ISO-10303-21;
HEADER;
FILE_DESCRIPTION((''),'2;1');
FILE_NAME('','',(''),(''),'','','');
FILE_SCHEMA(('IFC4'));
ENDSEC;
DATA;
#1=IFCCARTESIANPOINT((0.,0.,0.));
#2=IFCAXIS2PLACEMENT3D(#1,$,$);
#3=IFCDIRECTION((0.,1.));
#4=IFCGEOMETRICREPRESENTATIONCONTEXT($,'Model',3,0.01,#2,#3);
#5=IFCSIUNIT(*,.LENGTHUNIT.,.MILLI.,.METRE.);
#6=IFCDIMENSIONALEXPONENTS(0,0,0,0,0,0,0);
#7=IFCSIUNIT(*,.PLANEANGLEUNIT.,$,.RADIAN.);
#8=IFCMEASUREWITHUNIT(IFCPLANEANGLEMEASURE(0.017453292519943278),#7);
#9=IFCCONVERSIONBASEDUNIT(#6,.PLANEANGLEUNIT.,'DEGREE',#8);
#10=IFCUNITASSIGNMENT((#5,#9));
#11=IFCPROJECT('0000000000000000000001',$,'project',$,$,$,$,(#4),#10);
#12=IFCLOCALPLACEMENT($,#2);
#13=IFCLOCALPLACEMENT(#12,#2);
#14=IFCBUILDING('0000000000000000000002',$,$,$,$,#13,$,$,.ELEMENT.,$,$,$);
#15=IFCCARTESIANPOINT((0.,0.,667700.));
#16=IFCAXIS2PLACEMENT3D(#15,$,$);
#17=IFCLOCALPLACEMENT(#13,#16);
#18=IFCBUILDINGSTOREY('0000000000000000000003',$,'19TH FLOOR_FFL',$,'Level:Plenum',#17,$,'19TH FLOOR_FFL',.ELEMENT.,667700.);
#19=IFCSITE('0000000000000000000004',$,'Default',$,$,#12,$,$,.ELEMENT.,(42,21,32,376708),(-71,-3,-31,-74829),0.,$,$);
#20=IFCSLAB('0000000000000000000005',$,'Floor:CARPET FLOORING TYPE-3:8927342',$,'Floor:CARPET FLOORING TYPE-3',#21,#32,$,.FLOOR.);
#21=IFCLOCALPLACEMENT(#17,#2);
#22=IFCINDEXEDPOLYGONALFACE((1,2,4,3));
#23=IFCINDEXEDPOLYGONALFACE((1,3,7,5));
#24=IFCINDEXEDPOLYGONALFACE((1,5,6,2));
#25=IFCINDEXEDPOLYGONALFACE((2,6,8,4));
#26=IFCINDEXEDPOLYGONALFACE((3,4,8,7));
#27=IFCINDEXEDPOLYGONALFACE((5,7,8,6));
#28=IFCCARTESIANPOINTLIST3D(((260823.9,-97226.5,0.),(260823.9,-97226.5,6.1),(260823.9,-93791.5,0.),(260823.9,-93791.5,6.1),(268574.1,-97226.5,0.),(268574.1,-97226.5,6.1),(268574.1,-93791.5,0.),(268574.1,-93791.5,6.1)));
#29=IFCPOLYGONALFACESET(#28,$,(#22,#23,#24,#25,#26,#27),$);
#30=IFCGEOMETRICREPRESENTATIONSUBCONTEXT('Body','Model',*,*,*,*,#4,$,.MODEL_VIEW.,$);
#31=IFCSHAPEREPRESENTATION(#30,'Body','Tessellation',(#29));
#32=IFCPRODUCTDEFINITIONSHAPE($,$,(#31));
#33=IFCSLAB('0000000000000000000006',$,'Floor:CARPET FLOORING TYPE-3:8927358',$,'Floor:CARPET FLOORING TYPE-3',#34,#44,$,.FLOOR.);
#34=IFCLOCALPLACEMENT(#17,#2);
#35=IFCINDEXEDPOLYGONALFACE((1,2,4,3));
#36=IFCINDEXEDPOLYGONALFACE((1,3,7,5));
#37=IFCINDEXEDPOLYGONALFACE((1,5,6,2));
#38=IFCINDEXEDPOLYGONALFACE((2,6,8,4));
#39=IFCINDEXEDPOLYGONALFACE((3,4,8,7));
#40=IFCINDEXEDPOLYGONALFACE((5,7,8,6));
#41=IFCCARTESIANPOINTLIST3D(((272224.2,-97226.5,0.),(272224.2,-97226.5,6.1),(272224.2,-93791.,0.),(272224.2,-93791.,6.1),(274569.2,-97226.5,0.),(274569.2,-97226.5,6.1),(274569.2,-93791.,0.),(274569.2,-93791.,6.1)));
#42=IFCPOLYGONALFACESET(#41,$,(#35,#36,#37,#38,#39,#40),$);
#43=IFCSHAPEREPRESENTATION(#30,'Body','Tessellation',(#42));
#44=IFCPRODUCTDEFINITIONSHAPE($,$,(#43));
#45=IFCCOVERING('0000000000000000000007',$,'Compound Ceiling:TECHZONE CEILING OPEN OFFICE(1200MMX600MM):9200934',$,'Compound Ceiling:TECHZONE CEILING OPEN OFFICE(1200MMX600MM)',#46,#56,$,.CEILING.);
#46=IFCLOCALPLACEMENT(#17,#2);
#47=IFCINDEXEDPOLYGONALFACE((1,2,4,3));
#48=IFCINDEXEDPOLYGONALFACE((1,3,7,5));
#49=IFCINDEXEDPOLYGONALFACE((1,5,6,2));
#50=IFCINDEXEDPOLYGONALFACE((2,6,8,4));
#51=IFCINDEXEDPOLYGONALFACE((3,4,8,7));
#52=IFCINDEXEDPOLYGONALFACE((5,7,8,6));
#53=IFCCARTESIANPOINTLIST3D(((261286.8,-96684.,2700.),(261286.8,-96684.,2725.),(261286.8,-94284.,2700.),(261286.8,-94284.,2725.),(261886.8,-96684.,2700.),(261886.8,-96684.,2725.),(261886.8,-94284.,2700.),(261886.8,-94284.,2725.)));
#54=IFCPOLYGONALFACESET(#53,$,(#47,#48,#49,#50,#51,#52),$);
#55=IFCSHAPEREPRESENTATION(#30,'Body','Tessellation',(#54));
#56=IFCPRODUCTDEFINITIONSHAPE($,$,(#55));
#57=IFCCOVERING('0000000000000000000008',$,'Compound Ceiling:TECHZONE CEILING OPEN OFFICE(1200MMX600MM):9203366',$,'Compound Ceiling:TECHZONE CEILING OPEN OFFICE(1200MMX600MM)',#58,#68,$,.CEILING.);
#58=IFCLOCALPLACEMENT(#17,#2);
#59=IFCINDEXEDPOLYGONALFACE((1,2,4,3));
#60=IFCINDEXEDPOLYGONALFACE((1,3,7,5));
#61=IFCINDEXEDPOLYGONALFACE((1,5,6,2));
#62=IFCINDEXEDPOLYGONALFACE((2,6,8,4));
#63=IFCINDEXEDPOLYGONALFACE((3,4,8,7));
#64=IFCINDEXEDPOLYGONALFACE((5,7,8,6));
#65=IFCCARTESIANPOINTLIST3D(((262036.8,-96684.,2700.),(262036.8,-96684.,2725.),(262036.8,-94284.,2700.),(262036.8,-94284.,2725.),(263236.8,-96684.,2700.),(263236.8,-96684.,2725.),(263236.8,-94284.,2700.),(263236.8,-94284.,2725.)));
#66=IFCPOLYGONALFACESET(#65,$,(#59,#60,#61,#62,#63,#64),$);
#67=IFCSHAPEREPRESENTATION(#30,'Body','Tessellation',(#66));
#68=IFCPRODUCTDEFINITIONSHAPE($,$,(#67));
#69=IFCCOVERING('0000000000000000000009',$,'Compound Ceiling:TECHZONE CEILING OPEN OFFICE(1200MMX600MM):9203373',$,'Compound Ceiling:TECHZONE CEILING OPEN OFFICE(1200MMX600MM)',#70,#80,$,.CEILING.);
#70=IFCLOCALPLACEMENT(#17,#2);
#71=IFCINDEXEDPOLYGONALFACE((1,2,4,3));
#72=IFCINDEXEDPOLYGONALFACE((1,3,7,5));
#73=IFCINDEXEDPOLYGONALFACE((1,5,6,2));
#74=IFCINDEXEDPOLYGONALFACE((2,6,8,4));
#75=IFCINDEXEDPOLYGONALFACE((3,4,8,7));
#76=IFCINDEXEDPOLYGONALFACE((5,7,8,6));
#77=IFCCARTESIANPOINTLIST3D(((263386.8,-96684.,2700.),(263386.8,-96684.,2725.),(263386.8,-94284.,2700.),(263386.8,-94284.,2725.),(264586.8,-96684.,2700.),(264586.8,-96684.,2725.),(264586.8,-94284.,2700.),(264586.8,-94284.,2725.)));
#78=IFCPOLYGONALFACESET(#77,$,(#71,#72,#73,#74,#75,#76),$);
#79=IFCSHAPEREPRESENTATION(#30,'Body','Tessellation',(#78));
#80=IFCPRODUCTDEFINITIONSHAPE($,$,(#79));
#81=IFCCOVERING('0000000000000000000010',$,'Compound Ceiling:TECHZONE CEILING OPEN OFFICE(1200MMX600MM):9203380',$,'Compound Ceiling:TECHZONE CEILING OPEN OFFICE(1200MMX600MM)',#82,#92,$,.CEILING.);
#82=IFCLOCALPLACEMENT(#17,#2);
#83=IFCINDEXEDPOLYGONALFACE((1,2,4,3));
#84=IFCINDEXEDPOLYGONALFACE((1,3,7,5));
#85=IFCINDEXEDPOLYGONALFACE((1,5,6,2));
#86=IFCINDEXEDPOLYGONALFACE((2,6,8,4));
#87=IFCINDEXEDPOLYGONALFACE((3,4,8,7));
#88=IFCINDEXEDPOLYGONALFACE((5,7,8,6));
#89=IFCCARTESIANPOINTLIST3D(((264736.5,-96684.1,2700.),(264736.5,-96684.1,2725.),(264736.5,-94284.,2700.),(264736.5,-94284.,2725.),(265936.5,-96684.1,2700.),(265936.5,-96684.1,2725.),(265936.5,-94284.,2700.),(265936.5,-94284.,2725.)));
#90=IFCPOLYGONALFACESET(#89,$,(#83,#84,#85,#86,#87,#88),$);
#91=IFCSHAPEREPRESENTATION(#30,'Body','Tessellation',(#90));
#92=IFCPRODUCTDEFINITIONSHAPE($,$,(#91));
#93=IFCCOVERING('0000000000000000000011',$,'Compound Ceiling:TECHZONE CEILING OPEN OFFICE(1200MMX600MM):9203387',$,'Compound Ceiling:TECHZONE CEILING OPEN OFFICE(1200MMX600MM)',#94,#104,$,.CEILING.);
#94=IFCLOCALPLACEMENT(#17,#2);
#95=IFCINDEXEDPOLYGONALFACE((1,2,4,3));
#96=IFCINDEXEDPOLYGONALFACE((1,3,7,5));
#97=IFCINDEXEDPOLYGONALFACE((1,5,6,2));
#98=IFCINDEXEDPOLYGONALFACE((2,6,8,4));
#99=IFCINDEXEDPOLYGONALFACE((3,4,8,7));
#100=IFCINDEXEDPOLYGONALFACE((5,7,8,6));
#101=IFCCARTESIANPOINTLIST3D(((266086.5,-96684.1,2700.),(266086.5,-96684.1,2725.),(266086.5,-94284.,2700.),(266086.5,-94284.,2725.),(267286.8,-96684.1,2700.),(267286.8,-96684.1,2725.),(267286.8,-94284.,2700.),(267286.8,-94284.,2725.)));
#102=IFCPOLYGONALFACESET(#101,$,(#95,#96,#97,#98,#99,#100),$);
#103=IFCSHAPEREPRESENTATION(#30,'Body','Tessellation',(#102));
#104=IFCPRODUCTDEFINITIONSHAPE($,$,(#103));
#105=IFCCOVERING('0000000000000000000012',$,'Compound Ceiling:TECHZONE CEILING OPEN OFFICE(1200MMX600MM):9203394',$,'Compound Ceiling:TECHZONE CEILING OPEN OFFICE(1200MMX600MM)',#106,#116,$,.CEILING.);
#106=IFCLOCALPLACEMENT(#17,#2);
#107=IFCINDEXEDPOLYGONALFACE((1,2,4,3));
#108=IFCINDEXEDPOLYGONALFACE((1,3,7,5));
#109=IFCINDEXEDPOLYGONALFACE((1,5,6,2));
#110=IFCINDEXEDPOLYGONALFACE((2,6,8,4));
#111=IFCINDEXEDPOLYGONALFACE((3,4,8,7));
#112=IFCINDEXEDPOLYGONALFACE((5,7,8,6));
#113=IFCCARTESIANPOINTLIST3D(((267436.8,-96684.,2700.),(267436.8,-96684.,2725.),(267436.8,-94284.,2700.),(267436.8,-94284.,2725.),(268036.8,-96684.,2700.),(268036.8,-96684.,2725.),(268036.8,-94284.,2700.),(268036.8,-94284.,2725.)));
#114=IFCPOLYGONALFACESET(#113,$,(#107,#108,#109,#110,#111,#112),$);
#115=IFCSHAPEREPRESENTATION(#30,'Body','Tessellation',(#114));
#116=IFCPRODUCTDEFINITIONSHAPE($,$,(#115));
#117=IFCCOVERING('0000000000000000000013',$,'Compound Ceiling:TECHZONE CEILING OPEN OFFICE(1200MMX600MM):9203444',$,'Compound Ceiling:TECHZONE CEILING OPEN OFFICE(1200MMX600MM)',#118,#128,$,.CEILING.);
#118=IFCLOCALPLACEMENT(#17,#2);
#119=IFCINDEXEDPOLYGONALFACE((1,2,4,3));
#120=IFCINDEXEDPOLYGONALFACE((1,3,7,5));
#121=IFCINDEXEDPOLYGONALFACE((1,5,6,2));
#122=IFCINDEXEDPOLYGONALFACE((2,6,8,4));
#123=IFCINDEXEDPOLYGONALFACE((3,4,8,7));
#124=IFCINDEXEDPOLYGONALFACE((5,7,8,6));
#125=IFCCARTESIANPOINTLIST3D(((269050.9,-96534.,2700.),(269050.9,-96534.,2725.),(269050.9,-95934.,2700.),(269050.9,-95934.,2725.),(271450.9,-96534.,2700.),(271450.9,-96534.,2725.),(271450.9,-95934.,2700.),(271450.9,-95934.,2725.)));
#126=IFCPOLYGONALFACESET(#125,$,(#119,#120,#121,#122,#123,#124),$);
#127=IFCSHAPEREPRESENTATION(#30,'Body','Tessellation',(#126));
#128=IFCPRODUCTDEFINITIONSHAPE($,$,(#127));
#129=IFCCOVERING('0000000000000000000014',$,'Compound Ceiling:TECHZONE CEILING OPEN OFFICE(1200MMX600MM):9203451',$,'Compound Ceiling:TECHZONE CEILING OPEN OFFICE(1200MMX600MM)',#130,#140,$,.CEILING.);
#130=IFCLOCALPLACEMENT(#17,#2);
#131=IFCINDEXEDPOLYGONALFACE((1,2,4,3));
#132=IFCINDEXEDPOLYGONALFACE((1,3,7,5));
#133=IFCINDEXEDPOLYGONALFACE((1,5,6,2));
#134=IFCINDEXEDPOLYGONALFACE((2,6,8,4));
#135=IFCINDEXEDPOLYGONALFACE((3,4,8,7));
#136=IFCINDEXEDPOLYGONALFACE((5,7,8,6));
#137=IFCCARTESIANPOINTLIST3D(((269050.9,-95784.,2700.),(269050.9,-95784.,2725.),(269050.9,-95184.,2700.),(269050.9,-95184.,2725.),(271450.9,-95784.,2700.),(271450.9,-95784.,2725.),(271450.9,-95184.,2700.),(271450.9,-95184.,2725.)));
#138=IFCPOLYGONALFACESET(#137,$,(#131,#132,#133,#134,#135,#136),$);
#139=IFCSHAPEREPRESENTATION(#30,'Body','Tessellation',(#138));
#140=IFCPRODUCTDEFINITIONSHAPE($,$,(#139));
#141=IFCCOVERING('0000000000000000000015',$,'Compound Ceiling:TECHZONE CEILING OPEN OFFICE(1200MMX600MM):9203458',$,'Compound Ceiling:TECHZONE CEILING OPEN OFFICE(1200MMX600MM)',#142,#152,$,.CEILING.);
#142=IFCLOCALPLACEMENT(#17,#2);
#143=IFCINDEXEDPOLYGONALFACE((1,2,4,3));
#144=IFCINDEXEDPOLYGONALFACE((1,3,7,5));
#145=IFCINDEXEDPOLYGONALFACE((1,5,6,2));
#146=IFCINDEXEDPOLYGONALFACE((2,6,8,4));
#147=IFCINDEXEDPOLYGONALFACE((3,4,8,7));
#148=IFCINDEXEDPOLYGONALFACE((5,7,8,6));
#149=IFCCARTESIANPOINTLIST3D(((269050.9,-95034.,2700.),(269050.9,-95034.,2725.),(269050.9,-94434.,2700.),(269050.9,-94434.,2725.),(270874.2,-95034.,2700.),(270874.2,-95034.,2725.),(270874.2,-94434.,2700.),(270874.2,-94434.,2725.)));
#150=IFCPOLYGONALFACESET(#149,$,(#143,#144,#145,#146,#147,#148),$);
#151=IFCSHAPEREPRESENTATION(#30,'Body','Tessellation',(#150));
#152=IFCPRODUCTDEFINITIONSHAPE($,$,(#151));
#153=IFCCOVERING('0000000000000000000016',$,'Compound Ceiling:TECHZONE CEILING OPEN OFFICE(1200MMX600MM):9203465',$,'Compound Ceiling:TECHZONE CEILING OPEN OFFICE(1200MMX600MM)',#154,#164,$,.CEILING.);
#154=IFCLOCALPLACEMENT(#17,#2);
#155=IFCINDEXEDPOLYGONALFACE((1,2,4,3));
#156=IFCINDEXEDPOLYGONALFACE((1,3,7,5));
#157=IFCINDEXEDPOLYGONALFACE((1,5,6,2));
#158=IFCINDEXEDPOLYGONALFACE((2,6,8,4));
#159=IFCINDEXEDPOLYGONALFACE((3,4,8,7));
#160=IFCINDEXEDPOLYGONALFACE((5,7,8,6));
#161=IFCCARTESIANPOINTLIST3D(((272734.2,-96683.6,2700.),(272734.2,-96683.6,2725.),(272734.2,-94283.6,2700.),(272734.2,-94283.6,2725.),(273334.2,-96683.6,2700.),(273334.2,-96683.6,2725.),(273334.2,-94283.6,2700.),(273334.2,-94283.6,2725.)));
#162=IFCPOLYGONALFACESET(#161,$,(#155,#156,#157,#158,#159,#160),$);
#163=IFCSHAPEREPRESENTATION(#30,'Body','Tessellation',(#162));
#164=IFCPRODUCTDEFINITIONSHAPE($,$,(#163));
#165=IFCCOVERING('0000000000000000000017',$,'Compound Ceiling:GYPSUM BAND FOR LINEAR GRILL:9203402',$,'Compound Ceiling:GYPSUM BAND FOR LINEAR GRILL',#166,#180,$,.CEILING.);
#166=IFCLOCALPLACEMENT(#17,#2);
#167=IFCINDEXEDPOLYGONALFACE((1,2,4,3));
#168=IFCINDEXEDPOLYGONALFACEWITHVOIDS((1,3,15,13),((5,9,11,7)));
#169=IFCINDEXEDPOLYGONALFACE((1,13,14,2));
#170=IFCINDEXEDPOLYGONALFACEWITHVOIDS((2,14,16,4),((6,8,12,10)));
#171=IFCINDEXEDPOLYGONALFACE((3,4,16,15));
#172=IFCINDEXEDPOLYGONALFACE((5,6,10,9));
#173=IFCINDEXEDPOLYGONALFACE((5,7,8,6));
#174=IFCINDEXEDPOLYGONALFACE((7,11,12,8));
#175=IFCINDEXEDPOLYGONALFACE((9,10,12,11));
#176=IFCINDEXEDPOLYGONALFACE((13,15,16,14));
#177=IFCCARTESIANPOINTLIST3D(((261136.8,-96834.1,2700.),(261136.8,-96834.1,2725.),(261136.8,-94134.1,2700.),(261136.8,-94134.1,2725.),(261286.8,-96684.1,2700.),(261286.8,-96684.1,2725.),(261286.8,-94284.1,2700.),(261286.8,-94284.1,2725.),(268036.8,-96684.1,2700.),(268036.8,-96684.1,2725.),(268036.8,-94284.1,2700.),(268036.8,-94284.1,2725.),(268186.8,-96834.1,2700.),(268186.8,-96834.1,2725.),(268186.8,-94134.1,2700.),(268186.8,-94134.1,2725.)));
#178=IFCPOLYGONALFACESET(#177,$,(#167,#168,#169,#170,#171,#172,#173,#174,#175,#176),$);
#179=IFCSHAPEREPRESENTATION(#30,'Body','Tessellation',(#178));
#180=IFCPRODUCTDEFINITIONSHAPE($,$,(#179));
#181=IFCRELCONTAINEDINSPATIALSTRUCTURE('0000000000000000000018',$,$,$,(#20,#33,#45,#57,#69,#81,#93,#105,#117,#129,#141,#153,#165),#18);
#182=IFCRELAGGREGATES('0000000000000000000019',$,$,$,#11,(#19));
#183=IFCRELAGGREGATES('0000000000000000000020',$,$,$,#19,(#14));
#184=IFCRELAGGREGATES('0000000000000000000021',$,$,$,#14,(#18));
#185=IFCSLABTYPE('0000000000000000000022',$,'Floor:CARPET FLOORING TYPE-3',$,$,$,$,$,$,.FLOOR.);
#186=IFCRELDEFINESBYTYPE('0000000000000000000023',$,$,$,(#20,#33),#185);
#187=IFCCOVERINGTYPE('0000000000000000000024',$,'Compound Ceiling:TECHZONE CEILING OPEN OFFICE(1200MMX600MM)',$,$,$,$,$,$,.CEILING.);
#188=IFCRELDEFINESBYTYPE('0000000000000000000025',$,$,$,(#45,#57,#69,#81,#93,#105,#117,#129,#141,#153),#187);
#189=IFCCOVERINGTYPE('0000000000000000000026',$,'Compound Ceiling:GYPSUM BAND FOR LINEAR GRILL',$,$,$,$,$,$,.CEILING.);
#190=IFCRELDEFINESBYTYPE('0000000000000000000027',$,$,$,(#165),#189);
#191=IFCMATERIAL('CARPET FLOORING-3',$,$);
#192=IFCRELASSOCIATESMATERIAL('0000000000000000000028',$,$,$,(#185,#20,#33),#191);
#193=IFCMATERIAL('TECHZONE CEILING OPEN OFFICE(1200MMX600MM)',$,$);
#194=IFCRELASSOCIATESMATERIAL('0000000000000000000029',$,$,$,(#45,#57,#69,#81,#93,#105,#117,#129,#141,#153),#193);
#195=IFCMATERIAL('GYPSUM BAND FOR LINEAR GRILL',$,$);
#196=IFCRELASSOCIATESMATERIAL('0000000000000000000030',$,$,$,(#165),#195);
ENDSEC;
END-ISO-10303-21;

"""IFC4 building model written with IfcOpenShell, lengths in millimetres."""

from ifc_helpers import new_model, entity, si_unit, converted_unit, direction, frame, origin, place, context, subcontext, project, spatial, indexed_curve, outline, extrude, material, type_object, element, save


model = new_model("IFC4")

# Units and contexts
model_context = context("Model", 3, precision=0.01, world=origin(), true_north=direction((0.0, 1.0)))
body_context = subcontext(model_context, "Body", "Model", "MODEL_VIEW")
ifc_project = project(units=[si_unit("LENGTHUNIT", "METRE", prefix="MILLI"), converted_unit("PLANEANGLEUNIT", "DEGREE", entity("IfcPlaneAngleMeasure", 0.017453292519943278), si_unit("PLANEANGLEUNIT", "RADIAN"), dimensions=[0, 0, 0, 0, 0, 0, 0])], contexts=[model_context])

# Site, building, storey
site_placement = place(None, origin())
site = spatial("IfcSite", under=ifc_project, at=site_placement, Name="Default", CompositionType="ELEMENT", RefLatitude=(42, 21, 32, 376708), RefLongitude=(-71, -3, -31, -74829), RefElevation=0.0)
building_placement = place(site_placement, origin())
building = spatial("IfcBuilding", under=site, at=building_placement, CompositionType="ELEMENT")
storey_placement = place(building_placement, frame((0.0, 0.0, 667700.0)))
storey = spatial("IfcBuildingStorey", under=building, at=storey_placement, Name="19TH FLOOR_FFL", ObjectType="Level:Plenum", LongName="19TH FLOOR_FFL", CompositionType="ELEMENT", Elevation=667700.0)

# Slabs
ifc_material_1 = material(Name="CARPET FLOORING-3")
slab_type_1 = type_object("IfcSlabType", Name="Floor:CARPET FLOORING TYPE-3", PredefinedType="FLOOR", material=ifc_material_1)
slab_1_placement = place(storey_placement, origin())
element("IfcSlab", 1, at=slab_1_placement, inside=storey, type_object=slab_type_1, material=ifc_material_1, Name="Floor:CARPET FLOORING TYPE-3:8927342", ObjectType="Floor:CARPET FLOORING TYPE-3", PredefinedType="FLOOR", context=body_context, shape_type="SweptSolid", body=[
    extrude(outline(indexed_curve([(-1717.5, -3875.1), (1717.5, -3875.1), (1717.5, 3875.1), (-1717.5, 3875.1), (-1717.5, -3875.1)], self_intersect=False)), frame((264699.0, -95509.0, 6.1), z_axis=(0.0, 0.0, -1.0), x_axis=(0.0, 1.0, 0.0)), (0.0, 0.0, 1.0), 6.1),
])
slab_2_placement = place(storey_placement, origin())
element("IfcSlab", 2, at=slab_2_placement, inside=storey, type_object=slab_type_1, material=ifc_material_1, Name="Floor:CARPET FLOORING TYPE-3:8927358", ObjectType="Floor:CARPET FLOORING TYPE-3", PredefinedType="FLOOR", context=body_context, shape_type="SweptSolid", body=[
    extrude(outline(indexed_curve([(-1717.7, -1172.5), (1717.7, -1172.5), (1717.7, 1172.5), (-1717.7, 1172.5), (-1717.7, -1172.5)], self_intersect=False)), frame((273396.7, -95508.8, 6.1), z_axis=(0.0, 0.0, -1.0), x_axis=(0.0, 1.0, 0.0)), (0.0, 0.0, 1.0), 6.1),
])

# Coverings
ifc_material_2 = material(Name="TECHZONE CEILING OPEN OFFICE(1200MMX600MM)")
covering_type_1 = type_object("IfcCoveringType", Name="Compound Ceiling:TECHZONE CEILING OPEN OFFICE(1200MMX600MM)", PredefinedType="CEILING")
covering_1_placement = place(storey_placement, origin())
element("IfcCovering", 3, at=covering_1_placement, inside=storey, type_object=covering_type_1, material=ifc_material_2, Name="Compound Ceiling:TECHZONE CEILING OPEN OFFICE(1200MMX600MM):9200934", ObjectType="Compound Ceiling:TECHZONE CEILING OPEN OFFICE(1200MMX600MM)", PredefinedType="CEILING", context=body_context, shape_type="SweptSolid", body=[
    extrude(outline(indexed_curve([(-300.0, -1200.0), (300.0, -1200.0), (300.0, 1200.0), (-300.0, 1200.0), (-300.0, -1200.0)], self_intersect=False)), frame((261586.8, -95484.0, 2700.0), z_axis=(0.0, 0.0, 1.0), x_axis=(-1.0, 0.0, 0.0)), (0.0, 0.0, 1.0), 25.0),
])
covering_2_placement = place(storey_placement, origin())
element("IfcCovering", 4, at=covering_2_placement, inside=storey, type_object=covering_type_1, material=ifc_material_2, Name="Compound Ceiling:TECHZONE CEILING OPEN OFFICE(1200MMX600MM):9203366", ObjectType="Compound Ceiling:TECHZONE CEILING OPEN OFFICE(1200MMX600MM)", PredefinedType="CEILING", context=body_context, shape_type="SweptSolid", body=[
    extrude(outline(indexed_curve([(-600.0, -1200.0), (600.0, -1200.0), (600.0, 1200.0), (-600.0, 1200.0), (-600.0, -1200.0)], self_intersect=False)), frame((262636.8, -95484.0, 2700.0), z_axis=(0.0, 0.0, 1.0), x_axis=(-1.0, 0.0, 0.0)), (0.0, 0.0, 1.0), 25.0),
])
covering_3_placement = place(storey_placement, origin())
element("IfcCovering", 5, at=covering_3_placement, inside=storey, type_object=covering_type_1, material=ifc_material_2, Name="Compound Ceiling:TECHZONE CEILING OPEN OFFICE(1200MMX600MM):9203373", ObjectType="Compound Ceiling:TECHZONE CEILING OPEN OFFICE(1200MMX600MM)", PredefinedType="CEILING", context=body_context, shape_type="SweptSolid", body=[
    extrude(outline(indexed_curve([(-600.0, -1200.0), (600.0, -1200.0), (600.0, 1200.0), (-600.0, 1200.0), (-600.0, -1200.0)], self_intersect=False)), frame((263986.8, -95484.0, 2700.0), z_axis=(0.0, 0.0, 1.0), x_axis=(-1.0, 0.0, 0.0)), (0.0, 0.0, 1.0), 25.0),
])
covering_4_placement = place(storey_placement, origin())
element("IfcCovering", 6, at=covering_4_placement, inside=storey, type_object=covering_type_1, material=ifc_material_2, Name="Compound Ceiling:TECHZONE CEILING OPEN OFFICE(1200MMX600MM):9203380", ObjectType="Compound Ceiling:TECHZONE CEILING OPEN OFFICE(1200MMX600MM)", PredefinedType="CEILING", context=body_context, shape_type="SweptSolid", body=[
    extrude(outline(indexed_curve([(-600.0, -1200.1), (600.0, -1200.1), (600.0, 1200.1), (-600.0, 1200.1), (-600.0, -1200.1)], self_intersect=False)), frame((265336.5, -95484.1, 2700.0), z_axis=(0.0, 0.0, 1.0), x_axis=(-1.0, 0.0, 0.0)), (0.0, 0.0, 1.0), 25.0),
])
covering_5_placement = place(storey_placement, origin())
element("IfcCovering", 7, at=covering_5_placement, inside=storey, type_object=covering_type_1, material=ifc_material_2, Name="Compound Ceiling:TECHZONE CEILING OPEN OFFICE(1200MMX600MM):9203387", ObjectType="Compound Ceiling:TECHZONE CEILING OPEN OFFICE(1200MMX600MM)", PredefinedType="CEILING", context=body_context, shape_type="SweptSolid", body=[
    extrude(outline(indexed_curve([(-600.1, -1200.1), (600.1, -1200.1), (600.1, 1200.1), (-600.1, 1200.1), (-600.1, -1200.1)], self_intersect=False)), frame((266686.7, -95484.1, 2700.0), z_axis=(0.0, 0.0, 1.0), x_axis=(-1.0, 0.0, 0.0)), (0.0, 0.0, 1.0), 25.0),
])
covering_6_placement = place(storey_placement, origin())
element("IfcCovering", 8, at=covering_6_placement, inside=storey, type_object=covering_type_1, material=ifc_material_2, Name="Compound Ceiling:TECHZONE CEILING OPEN OFFICE(1200MMX600MM):9203394", ObjectType="Compound Ceiling:TECHZONE CEILING OPEN OFFICE(1200MMX600MM)", PredefinedType="CEILING", context=body_context, shape_type="SweptSolid", body=[
    extrude(outline(indexed_curve([(-300.0, -1200.0), (300.0, -1200.0), (300.0, 1200.0), (-300.0, 1200.0), (-300.0, -1200.0)], self_intersect=False)), frame((267736.8, -95484.0, 2700.0), z_axis=(0.0, 0.0, 1.0), x_axis=(-1.0, 0.0, 0.0)), (0.0, 0.0, 1.0), 25.0),
])
covering_7_placement = place(storey_placement, origin())
element("IfcCovering", 9, at=covering_7_placement, inside=storey, type_object=covering_type_1, material=ifc_material_2, Name="Compound Ceiling:TECHZONE CEILING OPEN OFFICE(1200MMX600MM):9203444", ObjectType="Compound Ceiling:TECHZONE CEILING OPEN OFFICE(1200MMX600MM)", PredefinedType="CEILING", context=body_context, shape_type="SweptSolid", body=[
    extrude(outline(indexed_curve([(-300.0, -1200.0), (300.0, -1200.0), (300.0, 1200.0), (-300.0, 1200.0), (-300.0, -1200.0)], self_intersect=False)), frame((270250.9, -96234.0, 2700.0), z_axis=(0.0, 0.0, 1.0), x_axis=(0.0, 1.0, 0.0)), (0.0, 0.0, 1.0), 25.0),
])
covering_8_placement = place(storey_placement, origin())
element("IfcCovering", 10, at=covering_8_placement, inside=storey, type_object=covering_type_1, material=ifc_material_2, Name="Compound Ceiling:TECHZONE CEILING OPEN OFFICE(1200MMX600MM):9203451", ObjectType="Compound Ceiling:TECHZONE CEILING OPEN OFFICE(1200MMX600MM)", PredefinedType="CEILING", context=body_context, shape_type="SweptSolid", body=[
    extrude(outline(indexed_curve([(-300.0, -1200.0), (300.0, -1200.0), (300.0, 1200.0), (-300.0, 1200.0), (-300.0, -1200.0)], self_intersect=False)), frame((270250.9, -95484.0, 2700.0), z_axis=(0.0, 0.0, 1.0), x_axis=(0.0, 1.0, 0.0)), (0.0, 0.0, 1.0), 25.0),
])
covering_9_placement = place(storey_placement, origin())
element("IfcCovering", 11, at=covering_9_placement, inside=storey, type_object=covering_type_1, material=ifc_material_2, Name="Compound Ceiling:TECHZONE CEILING OPEN OFFICE(1200MMX600MM):9203458", ObjectType="Compound Ceiling:TECHZONE CEILING OPEN OFFICE(1200MMX600MM)", PredefinedType="CEILING", context=body_context, shape_type="SweptSolid", body=[
    extrude(outline(indexed_curve([(-911.6, -300.0), (911.6, -300.0), (911.6, 300.0), (-911.6, 300.0), (-911.6, -300.0)], self_intersect=False)), frame((269962.6, -94734.0, 2700.0), z_axis=(0.0, 0.0, 1.0), x_axis=(-1.0, 0.0, 0.0)), (0.0, 0.0, 1.0), 25.0),
])
covering_10_placement = place(storey_placement, origin())
element("IfcCovering", 12, at=covering_10_placement, inside=storey, type_object=covering_type_1, material=ifc_material_2, Name="Compound Ceiling:TECHZONE CEILING OPEN OFFICE(1200MMX600MM):9203465", ObjectType="Compound Ceiling:TECHZONE CEILING OPEN OFFICE(1200MMX600MM)", PredefinedType="CEILING", context=body_context, shape_type="SweptSolid", body=[
    extrude(outline(indexed_curve([(-300.0, -1200.0), (300.0, -1200.0), (300.0, 1200.0), (-300.0, 1200.0), (-300.0, -1200.0)], self_intersect=False)), frame((273034.2, -95483.6, 2700.0), z_axis=(0.0, 0.0, 1.0), x_axis=(-1.0, 0.0, 0.0)), (0.0, 0.0, 1.0), 25.0),
])
ifc_material_3 = material(Name="GYPSUM BAND FOR LINEAR GRILL")
covering_type_2 = type_object("IfcCoveringType", Name="Compound Ceiling:GYPSUM BAND FOR LINEAR GRILL", PredefinedType="CEILING")
covering_11_placement = place(storey_placement, origin())
element("IfcCovering", 13, at=covering_11_placement, inside=storey, type_object=covering_type_2, material=ifc_material_3, Name="Compound Ceiling:GYPSUM BAND FOR LINEAR GRILL:9203402", ObjectType="Compound Ceiling:GYPSUM BAND FOR LINEAR GRILL", PredefinedType="CEILING", context=body_context, shape_type="SweptSolid", body=[
    extrude(outline(indexed_curve([(-3525.0, -1350.0), (3525.0, -1350.0), (3525.0, 1350.0), (-3525.0, 1350.0), (-3525.0, -1350.0)], self_intersect=False), holes=[indexed_curve([(3375.0, 1200.0), (3375.0, -1200.0), (-3375.0, -1200.0), (-3375.0, 1200.0), (3375.0, 1200.0)], self_intersect=False)]), frame((264661.8, -95484.1, 2700.0), z_axis=(0.0, 0.0, 1.0), x_axis=(-1.0, 0.0, 0.0)), (0.0, 0.0, 1.0), 25.0),
])

save(model, "model.ifc")
